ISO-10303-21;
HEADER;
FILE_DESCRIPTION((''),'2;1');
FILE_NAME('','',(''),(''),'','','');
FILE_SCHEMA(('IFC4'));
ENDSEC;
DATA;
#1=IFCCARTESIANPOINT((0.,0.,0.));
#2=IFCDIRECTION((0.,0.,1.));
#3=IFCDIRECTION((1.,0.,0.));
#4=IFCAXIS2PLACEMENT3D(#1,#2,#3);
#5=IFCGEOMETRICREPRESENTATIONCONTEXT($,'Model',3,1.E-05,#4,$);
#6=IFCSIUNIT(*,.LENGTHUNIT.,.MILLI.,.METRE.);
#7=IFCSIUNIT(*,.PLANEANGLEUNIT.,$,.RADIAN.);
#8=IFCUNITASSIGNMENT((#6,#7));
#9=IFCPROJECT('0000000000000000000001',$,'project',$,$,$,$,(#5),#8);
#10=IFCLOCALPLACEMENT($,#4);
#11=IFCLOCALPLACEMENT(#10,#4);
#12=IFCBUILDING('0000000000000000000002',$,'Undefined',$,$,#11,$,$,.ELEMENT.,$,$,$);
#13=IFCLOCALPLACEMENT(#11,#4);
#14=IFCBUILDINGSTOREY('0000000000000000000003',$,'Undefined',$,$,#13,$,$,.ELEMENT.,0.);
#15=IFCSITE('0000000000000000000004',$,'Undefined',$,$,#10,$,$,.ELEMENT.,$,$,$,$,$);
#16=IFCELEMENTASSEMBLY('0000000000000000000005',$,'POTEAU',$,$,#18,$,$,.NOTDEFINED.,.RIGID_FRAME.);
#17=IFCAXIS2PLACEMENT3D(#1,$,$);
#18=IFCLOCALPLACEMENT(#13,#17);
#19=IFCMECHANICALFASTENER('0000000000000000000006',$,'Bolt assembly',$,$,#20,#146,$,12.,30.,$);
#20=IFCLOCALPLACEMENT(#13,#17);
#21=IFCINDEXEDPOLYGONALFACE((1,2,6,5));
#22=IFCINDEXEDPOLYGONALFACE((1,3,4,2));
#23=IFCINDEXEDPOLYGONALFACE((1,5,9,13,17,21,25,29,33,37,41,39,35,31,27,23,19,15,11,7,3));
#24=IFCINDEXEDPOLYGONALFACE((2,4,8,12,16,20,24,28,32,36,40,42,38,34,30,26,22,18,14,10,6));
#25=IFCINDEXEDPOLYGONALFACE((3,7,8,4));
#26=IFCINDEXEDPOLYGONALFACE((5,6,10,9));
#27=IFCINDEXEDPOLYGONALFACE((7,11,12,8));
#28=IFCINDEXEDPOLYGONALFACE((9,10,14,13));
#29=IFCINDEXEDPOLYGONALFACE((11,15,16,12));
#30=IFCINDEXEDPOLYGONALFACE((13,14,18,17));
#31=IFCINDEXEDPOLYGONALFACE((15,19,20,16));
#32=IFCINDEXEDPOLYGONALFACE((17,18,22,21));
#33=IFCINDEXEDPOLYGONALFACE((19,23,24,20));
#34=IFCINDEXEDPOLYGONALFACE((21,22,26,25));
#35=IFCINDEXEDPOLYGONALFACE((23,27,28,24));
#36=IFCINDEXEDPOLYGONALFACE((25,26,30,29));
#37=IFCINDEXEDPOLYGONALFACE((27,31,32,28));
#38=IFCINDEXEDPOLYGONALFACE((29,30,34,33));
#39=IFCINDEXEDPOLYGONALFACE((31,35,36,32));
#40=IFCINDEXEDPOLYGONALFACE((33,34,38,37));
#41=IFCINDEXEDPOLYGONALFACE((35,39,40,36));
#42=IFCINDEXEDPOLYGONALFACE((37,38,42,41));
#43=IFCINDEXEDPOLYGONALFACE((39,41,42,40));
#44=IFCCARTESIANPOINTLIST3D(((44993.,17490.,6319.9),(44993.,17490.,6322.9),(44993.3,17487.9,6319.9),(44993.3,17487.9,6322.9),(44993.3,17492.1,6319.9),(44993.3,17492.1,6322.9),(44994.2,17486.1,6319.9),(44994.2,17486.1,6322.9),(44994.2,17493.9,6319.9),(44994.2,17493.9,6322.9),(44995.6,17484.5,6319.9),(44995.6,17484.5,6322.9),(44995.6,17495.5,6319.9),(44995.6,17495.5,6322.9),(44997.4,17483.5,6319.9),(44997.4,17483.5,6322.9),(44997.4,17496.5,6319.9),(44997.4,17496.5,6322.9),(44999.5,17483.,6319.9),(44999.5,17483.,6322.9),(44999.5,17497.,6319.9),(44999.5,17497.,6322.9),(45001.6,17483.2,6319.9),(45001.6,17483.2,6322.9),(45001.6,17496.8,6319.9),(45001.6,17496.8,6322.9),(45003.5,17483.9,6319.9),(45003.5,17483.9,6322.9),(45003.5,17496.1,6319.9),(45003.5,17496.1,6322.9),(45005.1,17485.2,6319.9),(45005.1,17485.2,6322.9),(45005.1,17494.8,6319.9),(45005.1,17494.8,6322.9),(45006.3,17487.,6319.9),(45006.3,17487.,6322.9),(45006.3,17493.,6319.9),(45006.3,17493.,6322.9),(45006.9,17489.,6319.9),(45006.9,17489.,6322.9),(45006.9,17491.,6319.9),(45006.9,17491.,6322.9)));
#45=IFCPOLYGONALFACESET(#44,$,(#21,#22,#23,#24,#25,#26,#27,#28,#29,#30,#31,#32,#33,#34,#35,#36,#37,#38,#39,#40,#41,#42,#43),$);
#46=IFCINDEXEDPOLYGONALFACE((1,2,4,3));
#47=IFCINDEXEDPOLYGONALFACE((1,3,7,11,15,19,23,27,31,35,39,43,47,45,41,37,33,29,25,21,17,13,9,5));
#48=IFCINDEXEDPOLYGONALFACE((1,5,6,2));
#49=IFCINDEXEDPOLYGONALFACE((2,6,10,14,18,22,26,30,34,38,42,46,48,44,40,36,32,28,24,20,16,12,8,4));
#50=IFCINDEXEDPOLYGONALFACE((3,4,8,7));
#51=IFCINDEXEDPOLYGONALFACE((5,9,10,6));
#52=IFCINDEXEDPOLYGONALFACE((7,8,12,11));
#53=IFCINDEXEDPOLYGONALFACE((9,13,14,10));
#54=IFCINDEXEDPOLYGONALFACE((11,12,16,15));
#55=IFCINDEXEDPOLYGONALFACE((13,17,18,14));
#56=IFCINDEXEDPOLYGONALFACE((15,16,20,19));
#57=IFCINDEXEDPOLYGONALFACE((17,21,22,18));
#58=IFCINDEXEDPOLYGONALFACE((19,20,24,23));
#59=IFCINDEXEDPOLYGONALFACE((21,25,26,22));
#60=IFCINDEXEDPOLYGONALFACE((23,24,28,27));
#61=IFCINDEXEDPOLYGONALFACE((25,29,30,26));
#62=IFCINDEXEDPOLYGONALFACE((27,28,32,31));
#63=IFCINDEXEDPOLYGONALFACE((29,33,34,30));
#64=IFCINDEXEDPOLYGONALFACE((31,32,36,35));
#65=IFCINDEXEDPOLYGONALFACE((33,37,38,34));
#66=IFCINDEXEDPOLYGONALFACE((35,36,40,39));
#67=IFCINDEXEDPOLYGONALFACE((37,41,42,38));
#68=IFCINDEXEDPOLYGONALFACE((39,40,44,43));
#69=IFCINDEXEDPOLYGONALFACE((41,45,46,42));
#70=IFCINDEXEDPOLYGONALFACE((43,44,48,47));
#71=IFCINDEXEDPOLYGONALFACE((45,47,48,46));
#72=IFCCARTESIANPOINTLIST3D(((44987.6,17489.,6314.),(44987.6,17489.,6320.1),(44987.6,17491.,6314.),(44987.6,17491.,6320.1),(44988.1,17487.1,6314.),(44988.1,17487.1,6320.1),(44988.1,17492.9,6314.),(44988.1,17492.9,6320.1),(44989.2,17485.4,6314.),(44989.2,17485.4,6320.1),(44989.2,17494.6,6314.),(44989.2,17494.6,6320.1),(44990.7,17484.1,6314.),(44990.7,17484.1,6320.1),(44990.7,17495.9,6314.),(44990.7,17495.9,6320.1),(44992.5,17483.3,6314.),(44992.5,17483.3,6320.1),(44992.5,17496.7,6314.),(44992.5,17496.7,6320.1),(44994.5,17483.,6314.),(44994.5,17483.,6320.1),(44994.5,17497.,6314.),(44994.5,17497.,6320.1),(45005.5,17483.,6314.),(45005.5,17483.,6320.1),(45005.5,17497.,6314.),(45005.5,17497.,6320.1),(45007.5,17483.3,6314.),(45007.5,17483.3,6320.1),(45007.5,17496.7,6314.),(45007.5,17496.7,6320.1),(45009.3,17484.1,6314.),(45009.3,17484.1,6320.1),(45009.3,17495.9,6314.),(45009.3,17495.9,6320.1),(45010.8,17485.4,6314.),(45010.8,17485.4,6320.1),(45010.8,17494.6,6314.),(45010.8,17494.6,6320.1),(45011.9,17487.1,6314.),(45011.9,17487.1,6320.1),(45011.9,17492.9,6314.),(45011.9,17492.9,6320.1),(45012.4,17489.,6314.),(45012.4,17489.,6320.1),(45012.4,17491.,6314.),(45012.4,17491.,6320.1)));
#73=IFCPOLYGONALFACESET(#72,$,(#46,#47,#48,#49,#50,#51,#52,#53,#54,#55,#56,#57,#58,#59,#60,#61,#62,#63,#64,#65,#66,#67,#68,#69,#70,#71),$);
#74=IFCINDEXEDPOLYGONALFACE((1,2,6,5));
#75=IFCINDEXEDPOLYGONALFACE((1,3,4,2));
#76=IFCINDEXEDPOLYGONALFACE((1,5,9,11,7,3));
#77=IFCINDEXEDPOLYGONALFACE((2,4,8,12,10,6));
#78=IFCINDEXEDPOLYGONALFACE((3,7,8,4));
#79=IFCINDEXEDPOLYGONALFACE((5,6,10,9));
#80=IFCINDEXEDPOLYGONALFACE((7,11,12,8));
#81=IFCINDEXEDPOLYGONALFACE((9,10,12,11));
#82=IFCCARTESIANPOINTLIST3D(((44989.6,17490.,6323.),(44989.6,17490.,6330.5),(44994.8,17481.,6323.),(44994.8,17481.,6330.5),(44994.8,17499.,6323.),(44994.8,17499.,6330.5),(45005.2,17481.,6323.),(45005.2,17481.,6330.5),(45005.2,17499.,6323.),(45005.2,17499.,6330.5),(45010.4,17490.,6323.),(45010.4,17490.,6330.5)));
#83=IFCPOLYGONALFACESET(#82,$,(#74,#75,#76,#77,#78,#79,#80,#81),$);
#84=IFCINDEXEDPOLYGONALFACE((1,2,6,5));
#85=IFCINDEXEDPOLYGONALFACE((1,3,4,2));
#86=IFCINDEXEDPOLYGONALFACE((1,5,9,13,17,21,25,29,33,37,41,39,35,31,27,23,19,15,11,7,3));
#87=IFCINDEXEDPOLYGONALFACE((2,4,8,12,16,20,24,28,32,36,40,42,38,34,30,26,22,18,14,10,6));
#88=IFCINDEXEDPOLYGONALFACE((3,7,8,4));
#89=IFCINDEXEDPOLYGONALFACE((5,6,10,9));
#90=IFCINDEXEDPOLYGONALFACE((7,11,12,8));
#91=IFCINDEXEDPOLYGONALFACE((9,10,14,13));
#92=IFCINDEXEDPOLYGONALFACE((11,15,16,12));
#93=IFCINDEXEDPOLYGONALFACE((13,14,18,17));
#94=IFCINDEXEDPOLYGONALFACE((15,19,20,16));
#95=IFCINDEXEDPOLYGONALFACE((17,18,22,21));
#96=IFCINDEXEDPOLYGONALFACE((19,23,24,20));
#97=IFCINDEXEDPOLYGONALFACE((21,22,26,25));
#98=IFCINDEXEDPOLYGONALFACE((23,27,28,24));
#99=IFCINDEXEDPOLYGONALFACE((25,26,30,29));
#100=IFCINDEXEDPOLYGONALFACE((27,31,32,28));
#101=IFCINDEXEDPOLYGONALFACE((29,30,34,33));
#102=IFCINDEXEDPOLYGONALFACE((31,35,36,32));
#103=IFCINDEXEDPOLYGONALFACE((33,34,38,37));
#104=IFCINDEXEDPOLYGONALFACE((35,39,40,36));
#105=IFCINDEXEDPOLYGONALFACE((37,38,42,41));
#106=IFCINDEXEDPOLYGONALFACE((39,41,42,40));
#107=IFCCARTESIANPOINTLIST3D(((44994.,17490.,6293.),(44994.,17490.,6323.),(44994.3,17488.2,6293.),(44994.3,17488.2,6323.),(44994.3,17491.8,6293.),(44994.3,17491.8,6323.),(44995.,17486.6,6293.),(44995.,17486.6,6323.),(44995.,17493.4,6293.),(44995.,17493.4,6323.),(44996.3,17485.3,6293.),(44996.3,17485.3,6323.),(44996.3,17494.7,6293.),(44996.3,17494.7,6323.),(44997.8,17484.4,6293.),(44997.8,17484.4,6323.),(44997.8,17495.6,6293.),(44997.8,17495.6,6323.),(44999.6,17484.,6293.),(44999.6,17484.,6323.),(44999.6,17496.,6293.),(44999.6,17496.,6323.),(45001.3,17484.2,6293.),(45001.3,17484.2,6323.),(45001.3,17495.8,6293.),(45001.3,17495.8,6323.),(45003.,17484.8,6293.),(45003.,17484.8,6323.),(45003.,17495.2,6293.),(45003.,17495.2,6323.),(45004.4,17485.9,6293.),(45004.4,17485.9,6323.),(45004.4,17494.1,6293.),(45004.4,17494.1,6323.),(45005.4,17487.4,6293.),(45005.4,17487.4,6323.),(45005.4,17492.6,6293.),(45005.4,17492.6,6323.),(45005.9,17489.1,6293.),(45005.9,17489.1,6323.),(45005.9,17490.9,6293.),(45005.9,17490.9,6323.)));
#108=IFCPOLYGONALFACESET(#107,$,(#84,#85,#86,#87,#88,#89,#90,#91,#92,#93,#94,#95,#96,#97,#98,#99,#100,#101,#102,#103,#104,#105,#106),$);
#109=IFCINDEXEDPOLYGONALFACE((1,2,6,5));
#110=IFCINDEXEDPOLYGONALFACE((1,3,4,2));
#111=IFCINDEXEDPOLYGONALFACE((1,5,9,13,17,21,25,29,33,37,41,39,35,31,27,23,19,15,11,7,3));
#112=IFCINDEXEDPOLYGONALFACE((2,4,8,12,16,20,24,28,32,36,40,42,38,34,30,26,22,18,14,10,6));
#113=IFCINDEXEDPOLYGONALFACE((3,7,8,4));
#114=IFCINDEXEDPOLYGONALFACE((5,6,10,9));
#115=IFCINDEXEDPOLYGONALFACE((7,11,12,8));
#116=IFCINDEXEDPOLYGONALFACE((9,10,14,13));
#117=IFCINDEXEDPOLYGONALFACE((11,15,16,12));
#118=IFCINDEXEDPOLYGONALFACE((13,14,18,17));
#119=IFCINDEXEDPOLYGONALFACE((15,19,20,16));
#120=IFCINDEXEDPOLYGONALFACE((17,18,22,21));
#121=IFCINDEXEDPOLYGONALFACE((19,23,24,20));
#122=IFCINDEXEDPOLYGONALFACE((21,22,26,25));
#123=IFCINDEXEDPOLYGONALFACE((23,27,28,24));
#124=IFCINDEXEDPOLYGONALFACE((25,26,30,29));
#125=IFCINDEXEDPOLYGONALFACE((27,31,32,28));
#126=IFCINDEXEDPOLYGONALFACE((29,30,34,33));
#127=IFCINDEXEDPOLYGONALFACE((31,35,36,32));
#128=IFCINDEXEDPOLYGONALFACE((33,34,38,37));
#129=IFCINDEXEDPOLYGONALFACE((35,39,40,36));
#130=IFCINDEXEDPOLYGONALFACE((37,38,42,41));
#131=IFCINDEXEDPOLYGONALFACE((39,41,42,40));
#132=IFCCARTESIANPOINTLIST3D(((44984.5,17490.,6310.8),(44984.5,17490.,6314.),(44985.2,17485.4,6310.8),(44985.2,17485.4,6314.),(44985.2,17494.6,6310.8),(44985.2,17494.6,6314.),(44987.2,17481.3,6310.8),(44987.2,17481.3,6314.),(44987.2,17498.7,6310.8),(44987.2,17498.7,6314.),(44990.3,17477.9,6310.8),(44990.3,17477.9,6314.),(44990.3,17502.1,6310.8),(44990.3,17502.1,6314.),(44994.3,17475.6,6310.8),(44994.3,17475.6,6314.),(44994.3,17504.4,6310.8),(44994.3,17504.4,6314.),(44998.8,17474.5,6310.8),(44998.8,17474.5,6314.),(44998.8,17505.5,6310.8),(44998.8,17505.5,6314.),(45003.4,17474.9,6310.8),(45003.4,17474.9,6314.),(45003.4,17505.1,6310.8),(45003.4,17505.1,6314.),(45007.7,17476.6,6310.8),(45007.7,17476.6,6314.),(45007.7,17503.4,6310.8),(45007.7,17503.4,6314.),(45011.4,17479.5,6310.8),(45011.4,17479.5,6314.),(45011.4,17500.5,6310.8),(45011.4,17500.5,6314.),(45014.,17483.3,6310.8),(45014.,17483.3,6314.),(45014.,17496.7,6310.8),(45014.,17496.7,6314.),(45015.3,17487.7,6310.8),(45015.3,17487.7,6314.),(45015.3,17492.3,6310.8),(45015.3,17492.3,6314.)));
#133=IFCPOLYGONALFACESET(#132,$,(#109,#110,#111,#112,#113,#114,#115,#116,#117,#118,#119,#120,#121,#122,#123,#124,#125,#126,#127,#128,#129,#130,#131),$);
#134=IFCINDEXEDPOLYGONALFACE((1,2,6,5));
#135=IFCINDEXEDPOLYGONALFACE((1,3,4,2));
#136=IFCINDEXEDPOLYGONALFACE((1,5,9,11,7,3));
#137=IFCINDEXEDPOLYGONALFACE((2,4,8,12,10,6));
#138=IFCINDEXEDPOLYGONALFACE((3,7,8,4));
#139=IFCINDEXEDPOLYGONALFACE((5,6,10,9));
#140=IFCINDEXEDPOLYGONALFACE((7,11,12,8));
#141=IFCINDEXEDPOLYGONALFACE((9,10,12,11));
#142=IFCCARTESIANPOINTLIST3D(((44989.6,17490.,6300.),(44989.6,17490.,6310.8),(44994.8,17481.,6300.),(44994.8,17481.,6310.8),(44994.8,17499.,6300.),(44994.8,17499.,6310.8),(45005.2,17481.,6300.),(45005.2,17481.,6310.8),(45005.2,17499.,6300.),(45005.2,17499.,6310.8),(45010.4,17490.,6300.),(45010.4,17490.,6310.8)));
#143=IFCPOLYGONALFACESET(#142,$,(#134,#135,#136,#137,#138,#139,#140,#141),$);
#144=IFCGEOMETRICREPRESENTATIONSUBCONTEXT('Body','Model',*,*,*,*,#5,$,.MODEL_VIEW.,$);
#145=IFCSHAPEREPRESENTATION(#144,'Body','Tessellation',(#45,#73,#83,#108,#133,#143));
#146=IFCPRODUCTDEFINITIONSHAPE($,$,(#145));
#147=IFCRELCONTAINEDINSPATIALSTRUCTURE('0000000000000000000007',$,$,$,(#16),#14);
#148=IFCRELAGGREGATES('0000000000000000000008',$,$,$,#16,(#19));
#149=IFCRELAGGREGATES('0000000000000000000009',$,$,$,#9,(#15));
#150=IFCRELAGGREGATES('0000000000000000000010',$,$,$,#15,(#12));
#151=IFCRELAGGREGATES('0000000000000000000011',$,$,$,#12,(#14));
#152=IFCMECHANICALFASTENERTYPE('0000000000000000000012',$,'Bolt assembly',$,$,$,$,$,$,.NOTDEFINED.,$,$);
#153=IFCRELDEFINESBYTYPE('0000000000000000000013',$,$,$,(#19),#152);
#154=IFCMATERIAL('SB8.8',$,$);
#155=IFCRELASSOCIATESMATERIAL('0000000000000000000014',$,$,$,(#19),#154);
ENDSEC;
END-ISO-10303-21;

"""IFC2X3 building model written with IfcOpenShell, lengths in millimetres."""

from ifc_helpers import new_model, si_unit, frame, frame_2d, origin_with_axes, origin_2d_with_axis, place, context, subcontext, project, spatial, polyline, circle_curve, parameter, trimmed, segment, composite_curve, circle, outline, extrude, source, transform, mapped, material, type_object, element, aggregate, save


model = new_model("IFC2X3")

# Units and contexts
model_context = context("Model", 3, precision=1e-05, world=origin_with_axes())
body_context = subcontext(model_context, "Body", "Model", "MODEL_VIEW")
ifc_project = project(units=[si_unit("LENGTHUNIT", "METRE", prefix="MILLI"), si_unit("PLANEANGLEUNIT", "RADIAN")], contexts=[model_context])

# Site, building, storey
site_placement = place(None, origin_with_axes())
site = spatial("IfcSite", under=ifc_project, at=site_placement, Name="Undefined", CompositionType="ELEMENT")
building_placement = place(site_placement, origin_with_axes())
building = spatial("IfcBuilding", under=site, at=building_placement, Name="Undefined", CompositionType="ELEMENT")
storey_placement = place(building_placement, origin_with_axes())
storey = spatial("IfcBuildingStorey", under=building, at=storey_placement, Name="Undefined", CompositionType="ELEMENT", Elevation=0.0)

# Element assembly
assembly_1_placement = place(storey_placement, origin_with_axes())
assembly_1 = element("IfcElementAssembly", 1, at=assembly_1_placement, inside=storey, Name="POTEAU", AssemblyPlace="NOTDEFINED", PredefinedType="RIGID_FRAME")

# Mechanical fastener
ifc_material_1 = material(Name="SB8.8")
mechanical_fastener_type = type_object("IfcMechanicalFastenerType", Name="Bolt assembly")
shared_shape_1 = source(origin_with_axes(), body_context, "Body", "SweptSolid", [
    extrude(circle(Radius=7.0, at=origin_2d_with_axis()), frame((0.0, -2.9, 0.0), z_axis=(0.0, 1.0, 0.0), x_axis=(1.0, 0.0, 0.0)), (0.0, 0.0, 1.0), 3.0),
    extrude(outline(composite_curve([segment(polyline([(-5.5, 7.0), (5.5, 7.0)]), True, "CONTINUOUS"), segment(trimmed(circle_curve(frame_2d((5.5, 0.0), x_axis=(0.0, 1.0)), 7.0), [parameter(0.0)], [parameter(3.141593)], False, "PARAMETER"), True, "CONTINUOUS"), segment(polyline([(5.5, -7.0), (-5.5, -7.0)]), True, "CONTINUOUS"), segment(trimmed(circle_curve(frame_2d((-5.5, 0.0), x_axis=(0.0, -1.0)), 7.0), [parameter(0.0)], [parameter(3.141593)], False, "PARAMETER"), True, "DISCONTINUOUS")], self_intersect=False)), frame((0.0, -0.1, 0.0), z_axis=(0.0, 1.0, 0.0), x_axis=(1.0, 0.0, 0.0)), (0.0, 0.0, 1.0), 6.1),
    extrude(outline(polyline([(10.4, 0.0), (5.2, 9.0), (-5.2, 9.0), (-10.4, 0.0), (-5.2, -9.0), (5.2, -9.0), (10.4, 0.0)])), frame((0.0, -10.5, 0.0), z_axis=(0.0, 1.0, 0.0), x_axis=(1.0, 0.0, 0.0)), (0.0, 0.0, 1.0), 7.5),
    extrude(circle(Radius=6.0, at=origin_2d_with_axis()), frame((0.0, -3.0, 0.0), z_axis=(0.0, 1.0, 0.0), x_axis=(1.0, 0.0, 0.0)), (0.0, 0.0, 1.0), 30.0),
    extrude(circle(Radius=15.5, at=origin_2d_with_axis()), frame((0.0, 6.0, 0.0), z_axis=(0.0, 1.0, 0.0), x_axis=(1.0, 0.0, 0.0)), (0.0, 0.0, 1.0), 3.2),
    extrude(outline(polyline([(10.4, 0.0), (5.2, 9.0), (-5.2, 9.0), (-10.4, 0.0), (-5.2, -9.0), (5.2, -9.0), (10.4, 0.0)])), frame((0.0, 9.2, 0.0), z_axis=(0.0, 1.0, 0.0), x_axis=(1.0, 0.0, 0.0)), (0.0, 0.0, 1.0), 10.8),
])
mechanical_fastener_1_placement = place(assembly_1_placement, frame((45000.0, 17490.0, 6320.0), z_axis=(0.0, -1.0, 0.0), x_axis=(-1.0, 0.0, 0.0)))
mechanical_fastener_1 = element("IfcMechanicalFastener", 2, at=mechanical_fastener_1_placement, type_object=mechanical_fastener_type, material=ifc_material_1, Name="Bolt assembly", NominalDiameter=12.0, NominalLength=30.0, context=body_context, shape_type="MappedRepresentation", body=[
    mapped(shared_shape_1, transform((0.0, 0.0, 0.0))),
])
aggregate(assembly_1, [mechanical_fastener_1])

save(model, "model.ifc")
